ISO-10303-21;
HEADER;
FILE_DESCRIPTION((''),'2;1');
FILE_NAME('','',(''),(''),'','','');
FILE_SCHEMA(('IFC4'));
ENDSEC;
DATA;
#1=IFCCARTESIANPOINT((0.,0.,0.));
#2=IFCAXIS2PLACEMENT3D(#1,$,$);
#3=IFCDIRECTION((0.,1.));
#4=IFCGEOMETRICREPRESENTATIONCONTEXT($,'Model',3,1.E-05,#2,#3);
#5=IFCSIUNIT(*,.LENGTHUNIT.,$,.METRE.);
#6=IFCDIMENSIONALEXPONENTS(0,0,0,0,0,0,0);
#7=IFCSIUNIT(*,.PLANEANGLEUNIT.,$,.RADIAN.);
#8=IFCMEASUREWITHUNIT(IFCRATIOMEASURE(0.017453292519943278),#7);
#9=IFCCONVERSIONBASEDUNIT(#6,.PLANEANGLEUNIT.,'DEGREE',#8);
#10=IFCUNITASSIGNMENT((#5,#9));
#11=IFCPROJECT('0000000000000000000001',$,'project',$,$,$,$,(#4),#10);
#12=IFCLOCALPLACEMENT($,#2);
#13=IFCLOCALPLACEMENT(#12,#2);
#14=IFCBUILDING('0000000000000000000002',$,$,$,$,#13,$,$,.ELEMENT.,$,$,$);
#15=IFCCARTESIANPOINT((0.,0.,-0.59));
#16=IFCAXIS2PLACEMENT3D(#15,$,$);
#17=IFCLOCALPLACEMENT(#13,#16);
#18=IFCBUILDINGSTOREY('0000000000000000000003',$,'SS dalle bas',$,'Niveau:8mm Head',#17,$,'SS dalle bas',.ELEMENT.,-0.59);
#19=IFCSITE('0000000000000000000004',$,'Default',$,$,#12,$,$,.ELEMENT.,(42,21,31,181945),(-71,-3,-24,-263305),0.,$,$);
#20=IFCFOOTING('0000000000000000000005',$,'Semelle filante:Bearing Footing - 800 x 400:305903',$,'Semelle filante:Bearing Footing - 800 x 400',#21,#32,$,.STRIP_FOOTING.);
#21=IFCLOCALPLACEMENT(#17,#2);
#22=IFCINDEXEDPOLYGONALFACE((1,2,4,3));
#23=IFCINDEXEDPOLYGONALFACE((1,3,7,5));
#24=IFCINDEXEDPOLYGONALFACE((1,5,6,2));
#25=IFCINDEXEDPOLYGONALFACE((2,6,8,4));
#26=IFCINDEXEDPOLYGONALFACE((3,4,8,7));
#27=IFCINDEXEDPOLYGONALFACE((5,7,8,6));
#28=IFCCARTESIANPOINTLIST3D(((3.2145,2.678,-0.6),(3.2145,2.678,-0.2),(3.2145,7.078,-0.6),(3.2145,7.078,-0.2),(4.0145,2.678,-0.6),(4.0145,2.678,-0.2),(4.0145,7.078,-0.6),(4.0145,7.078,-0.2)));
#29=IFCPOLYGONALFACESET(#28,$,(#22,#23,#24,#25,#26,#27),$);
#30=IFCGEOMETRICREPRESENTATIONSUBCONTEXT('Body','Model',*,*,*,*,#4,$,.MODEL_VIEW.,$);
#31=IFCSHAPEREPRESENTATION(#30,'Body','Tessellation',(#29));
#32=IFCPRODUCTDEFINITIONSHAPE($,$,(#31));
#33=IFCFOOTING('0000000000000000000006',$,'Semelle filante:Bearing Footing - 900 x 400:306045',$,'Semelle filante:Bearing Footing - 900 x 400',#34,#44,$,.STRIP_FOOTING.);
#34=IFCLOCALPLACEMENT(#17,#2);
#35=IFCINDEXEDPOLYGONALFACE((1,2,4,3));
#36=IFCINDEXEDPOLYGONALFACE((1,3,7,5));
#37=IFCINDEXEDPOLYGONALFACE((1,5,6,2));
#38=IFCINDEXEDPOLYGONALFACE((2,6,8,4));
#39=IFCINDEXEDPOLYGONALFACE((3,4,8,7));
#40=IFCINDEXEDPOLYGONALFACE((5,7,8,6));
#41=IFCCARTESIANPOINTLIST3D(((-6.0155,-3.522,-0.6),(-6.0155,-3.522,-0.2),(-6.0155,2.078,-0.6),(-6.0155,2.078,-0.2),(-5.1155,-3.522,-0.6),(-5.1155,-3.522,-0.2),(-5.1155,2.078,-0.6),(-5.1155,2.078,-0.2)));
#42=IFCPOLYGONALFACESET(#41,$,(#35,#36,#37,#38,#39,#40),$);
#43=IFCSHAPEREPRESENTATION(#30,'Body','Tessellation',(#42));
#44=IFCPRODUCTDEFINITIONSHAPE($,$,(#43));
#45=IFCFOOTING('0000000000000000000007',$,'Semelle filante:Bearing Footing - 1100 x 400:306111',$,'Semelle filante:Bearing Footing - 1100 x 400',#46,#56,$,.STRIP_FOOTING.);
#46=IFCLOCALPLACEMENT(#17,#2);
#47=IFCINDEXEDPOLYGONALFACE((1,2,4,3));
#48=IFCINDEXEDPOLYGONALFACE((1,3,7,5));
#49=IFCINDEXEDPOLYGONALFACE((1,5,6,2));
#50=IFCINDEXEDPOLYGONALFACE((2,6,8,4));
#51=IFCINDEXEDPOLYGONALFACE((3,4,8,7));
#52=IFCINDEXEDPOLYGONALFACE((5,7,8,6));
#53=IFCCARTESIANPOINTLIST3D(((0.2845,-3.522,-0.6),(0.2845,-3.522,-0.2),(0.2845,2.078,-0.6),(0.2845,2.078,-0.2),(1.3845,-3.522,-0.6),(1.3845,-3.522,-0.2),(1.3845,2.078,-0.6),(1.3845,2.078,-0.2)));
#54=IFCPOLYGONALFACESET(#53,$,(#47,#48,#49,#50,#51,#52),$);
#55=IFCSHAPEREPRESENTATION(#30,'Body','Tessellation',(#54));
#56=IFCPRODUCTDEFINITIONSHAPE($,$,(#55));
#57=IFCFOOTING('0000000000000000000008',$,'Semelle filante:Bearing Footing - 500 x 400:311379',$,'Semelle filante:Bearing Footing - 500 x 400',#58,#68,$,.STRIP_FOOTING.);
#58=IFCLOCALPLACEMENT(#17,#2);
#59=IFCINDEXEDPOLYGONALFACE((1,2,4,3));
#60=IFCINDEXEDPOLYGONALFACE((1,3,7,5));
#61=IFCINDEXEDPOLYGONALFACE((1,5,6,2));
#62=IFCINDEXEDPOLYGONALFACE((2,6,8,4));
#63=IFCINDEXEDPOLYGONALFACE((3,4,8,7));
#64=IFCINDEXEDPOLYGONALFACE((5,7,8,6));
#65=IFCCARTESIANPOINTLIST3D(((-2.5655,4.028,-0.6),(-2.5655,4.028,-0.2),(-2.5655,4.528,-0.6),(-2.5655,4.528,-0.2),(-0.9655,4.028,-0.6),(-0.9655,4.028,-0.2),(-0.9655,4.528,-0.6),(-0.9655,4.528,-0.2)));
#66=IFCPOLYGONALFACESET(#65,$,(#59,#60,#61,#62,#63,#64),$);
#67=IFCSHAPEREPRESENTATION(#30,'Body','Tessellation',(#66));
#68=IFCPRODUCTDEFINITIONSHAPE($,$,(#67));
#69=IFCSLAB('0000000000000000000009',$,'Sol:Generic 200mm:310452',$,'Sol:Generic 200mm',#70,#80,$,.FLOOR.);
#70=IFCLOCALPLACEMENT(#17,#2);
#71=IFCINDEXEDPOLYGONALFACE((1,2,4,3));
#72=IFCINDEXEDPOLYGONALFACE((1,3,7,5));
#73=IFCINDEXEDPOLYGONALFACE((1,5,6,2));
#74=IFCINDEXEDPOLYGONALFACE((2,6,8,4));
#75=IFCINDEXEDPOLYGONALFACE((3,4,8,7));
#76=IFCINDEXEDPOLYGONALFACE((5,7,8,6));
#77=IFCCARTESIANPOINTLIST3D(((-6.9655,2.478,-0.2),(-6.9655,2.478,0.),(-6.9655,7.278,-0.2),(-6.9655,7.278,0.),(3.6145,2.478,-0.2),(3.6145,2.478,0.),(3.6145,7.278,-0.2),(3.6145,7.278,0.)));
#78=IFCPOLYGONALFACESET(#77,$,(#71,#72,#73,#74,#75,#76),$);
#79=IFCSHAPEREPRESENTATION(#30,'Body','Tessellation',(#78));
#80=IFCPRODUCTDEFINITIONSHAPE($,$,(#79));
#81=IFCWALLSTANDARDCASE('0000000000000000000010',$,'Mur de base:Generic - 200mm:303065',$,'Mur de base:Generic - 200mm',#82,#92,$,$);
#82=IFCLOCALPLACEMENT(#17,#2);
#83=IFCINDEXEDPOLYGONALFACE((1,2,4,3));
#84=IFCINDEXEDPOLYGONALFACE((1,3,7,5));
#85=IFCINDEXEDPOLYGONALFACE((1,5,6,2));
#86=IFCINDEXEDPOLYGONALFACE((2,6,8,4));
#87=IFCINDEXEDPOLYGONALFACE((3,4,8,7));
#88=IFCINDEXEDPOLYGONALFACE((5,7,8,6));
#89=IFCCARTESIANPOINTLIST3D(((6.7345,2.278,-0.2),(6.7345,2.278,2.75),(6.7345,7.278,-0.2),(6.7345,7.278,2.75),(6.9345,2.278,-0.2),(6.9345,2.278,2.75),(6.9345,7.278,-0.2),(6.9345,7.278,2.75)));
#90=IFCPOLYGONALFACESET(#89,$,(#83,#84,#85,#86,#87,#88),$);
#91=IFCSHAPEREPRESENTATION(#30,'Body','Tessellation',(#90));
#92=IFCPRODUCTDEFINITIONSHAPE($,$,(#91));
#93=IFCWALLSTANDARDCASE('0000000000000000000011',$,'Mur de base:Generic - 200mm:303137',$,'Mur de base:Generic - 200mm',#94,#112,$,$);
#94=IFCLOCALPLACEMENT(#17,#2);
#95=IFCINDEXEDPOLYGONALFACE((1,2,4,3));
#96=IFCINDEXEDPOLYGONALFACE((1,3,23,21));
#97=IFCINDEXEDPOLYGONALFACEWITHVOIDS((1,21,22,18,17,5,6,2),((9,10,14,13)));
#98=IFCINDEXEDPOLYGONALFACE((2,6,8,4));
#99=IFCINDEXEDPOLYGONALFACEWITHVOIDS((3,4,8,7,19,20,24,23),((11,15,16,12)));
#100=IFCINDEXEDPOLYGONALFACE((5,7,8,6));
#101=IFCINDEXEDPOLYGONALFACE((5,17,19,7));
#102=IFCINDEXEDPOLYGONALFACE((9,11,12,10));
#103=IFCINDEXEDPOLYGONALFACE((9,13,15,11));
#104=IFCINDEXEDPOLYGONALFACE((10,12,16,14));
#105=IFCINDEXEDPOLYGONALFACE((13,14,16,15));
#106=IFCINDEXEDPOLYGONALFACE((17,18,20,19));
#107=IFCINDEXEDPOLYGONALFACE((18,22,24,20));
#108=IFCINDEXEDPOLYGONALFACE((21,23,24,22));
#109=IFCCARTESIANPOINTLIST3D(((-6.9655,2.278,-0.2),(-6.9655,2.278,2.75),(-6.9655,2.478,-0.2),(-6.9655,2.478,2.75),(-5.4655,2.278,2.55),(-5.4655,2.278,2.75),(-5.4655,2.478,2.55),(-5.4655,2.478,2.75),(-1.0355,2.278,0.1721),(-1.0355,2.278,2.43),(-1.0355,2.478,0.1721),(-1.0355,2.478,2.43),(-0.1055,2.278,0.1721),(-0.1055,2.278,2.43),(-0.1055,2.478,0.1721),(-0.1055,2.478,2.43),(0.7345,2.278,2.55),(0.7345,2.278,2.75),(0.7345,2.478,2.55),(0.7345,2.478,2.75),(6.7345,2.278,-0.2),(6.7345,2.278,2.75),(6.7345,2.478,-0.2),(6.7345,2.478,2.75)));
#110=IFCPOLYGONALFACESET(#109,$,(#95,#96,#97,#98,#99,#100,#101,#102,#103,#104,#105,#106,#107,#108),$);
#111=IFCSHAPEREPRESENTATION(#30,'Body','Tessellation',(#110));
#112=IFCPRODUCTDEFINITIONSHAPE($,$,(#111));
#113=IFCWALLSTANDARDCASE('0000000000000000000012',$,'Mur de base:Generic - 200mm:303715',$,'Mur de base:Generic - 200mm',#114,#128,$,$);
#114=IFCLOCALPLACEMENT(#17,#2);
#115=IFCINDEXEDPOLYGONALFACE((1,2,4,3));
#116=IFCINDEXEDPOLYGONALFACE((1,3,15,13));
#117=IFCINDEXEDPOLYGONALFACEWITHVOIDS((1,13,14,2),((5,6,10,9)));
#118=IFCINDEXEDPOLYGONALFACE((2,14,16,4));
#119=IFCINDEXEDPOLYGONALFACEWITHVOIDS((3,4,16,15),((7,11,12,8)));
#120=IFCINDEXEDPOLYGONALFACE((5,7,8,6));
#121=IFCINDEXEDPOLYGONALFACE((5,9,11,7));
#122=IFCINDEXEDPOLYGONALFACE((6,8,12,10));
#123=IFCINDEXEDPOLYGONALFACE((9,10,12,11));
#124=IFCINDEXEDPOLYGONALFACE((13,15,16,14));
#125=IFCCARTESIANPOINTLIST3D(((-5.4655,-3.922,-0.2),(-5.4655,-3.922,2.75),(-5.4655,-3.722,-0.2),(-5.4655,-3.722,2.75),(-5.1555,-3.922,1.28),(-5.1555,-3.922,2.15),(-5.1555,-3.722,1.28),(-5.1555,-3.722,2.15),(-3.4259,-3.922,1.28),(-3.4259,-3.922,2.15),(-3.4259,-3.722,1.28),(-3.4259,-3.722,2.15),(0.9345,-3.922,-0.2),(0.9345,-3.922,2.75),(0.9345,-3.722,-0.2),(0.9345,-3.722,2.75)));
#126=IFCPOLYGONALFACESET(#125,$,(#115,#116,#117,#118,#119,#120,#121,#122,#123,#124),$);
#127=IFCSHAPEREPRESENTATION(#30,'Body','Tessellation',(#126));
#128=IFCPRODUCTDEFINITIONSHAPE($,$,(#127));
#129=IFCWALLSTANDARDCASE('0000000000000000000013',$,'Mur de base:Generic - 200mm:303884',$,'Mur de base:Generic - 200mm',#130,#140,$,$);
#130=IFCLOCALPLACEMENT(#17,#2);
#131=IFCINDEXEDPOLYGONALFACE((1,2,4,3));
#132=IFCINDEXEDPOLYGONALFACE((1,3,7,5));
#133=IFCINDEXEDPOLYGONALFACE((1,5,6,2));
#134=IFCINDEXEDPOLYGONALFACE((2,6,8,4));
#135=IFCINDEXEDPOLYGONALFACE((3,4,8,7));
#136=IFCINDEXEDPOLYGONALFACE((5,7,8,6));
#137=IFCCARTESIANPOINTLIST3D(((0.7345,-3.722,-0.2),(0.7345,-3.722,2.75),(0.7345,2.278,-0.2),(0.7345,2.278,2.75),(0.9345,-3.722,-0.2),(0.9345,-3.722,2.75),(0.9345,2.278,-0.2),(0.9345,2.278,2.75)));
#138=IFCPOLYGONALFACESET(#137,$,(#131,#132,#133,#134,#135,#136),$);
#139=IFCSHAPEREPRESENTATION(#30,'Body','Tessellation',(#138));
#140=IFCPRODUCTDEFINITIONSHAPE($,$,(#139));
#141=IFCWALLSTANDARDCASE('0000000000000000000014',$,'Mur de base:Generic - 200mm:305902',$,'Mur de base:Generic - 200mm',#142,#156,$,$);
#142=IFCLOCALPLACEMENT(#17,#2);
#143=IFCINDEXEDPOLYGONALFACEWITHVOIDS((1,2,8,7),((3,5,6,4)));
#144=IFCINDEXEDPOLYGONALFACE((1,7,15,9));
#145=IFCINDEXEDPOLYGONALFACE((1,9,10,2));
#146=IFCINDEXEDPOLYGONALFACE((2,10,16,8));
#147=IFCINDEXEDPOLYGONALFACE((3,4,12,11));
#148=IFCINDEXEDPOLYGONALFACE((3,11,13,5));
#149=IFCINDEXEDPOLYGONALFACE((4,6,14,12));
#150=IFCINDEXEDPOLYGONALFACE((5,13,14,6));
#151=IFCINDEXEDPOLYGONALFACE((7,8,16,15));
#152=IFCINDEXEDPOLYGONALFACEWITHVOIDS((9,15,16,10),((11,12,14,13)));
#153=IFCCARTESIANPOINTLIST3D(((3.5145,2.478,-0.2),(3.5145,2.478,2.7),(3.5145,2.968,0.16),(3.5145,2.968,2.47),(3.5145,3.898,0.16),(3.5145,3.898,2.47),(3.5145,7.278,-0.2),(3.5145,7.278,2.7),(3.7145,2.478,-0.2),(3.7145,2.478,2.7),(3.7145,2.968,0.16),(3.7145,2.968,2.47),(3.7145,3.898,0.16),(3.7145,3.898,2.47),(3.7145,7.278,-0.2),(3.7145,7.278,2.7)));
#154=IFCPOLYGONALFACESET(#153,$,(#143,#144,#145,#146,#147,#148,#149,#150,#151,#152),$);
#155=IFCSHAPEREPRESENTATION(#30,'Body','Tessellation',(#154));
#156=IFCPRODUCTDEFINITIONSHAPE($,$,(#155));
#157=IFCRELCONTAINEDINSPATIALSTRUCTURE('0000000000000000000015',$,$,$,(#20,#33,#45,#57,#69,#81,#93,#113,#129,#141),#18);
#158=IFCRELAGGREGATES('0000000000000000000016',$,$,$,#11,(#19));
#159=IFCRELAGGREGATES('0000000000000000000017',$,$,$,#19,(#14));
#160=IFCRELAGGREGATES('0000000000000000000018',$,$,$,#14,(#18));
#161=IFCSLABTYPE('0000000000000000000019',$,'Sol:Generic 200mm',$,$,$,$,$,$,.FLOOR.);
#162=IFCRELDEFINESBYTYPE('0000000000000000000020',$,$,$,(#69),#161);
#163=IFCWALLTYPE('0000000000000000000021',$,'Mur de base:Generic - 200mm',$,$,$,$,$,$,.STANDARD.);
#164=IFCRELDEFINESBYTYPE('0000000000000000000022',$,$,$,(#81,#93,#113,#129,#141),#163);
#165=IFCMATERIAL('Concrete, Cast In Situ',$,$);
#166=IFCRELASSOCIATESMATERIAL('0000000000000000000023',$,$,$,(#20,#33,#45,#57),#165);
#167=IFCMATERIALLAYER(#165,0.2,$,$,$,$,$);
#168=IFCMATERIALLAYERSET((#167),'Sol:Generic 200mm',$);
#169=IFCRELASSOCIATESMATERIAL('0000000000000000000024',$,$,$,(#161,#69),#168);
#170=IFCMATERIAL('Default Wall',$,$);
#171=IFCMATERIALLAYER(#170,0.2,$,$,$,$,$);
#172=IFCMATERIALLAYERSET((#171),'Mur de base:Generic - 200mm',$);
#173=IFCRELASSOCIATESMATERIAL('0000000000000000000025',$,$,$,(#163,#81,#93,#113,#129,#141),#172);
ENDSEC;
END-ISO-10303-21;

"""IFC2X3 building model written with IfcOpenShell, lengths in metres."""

from ifc_helpers import new_model, entity, si_unit, converted_unit, direction, frame, frame_2d, origin, origin_2d_with_axis, place, context, subcontext, project, spatial, polyline, rectangle, extrude, clip, bounded_halfspace, material, layer, layer_set, layer_usage, type_object, element, save


model = new_model("IFC2X3")

# Units and contexts
model_context = context("Model", 3, precision=1e-05, world=origin(), true_north=direction((0.0, 1.0)))
body_context = subcontext(model_context, "Body", "Model", "MODEL_VIEW")
ifc_project = project(units=[si_unit("LENGTHUNIT", "METRE"), converted_unit("PLANEANGLEUNIT", "DEGREE", entity("IfcRatioMeasure", 0.017453292519943278), si_unit("PLANEANGLEUNIT", "RADIAN"), dimensions=[0, 0, 0, 0, 0, 0, 0])], contexts=[model_context])

# Site, building, storey
site_placement = place(None, origin())
site = spatial("IfcSite", under=ifc_project, at=site_placement, Name="Default", CompositionType="ELEMENT", RefLatitude=(42, 21, 31, 181945), RefLongitude=(-71, -3, -24, -263305), RefElevation=0.0)
building_placement = place(site_placement, origin())
building = spatial("IfcBuilding", under=site, at=building_placement, CompositionType="ELEMENT")
storey_placement = place(building_placement, frame((0.0, 0.0, -0.59)))
storey = spatial("IfcBuildingStorey", under=building, at=storey_placement, Name="SS dalle bas", ObjectType="Niveau:8mm Head", LongName="SS dalle bas", CompositionType="ELEMENT", Elevation=-0.59)

# Footings
ifc_material_1 = material(Name="Concrete, Cast In Situ")
footing_1_placement = place(storey_placement, origin())
element("IfcFooting", 1, at=footing_1_placement, inside=storey, material=ifc_material_1, Name="Semelle filante:Bearing Footing - 800 x 400:305903", ObjectType="Semelle filante:Bearing Footing - 800 x 400", PredefinedType="STRIP_FOOTING", context=body_context, shape_type="SweptSolid", body=[
    extrude(rectangle(XDim=4.4, YDim=0.8, at=frame_2d((0.0, 0.0), x_axis=(1.0, 0.0))), frame((3.6145, 4.878, -0.6), z_axis=(0.0, 0.0, 1.0), x_axis=(0.0, -1.0, 0.0)), (0.0, 0.0, 1.0), 0.4),
])
footing_2_placement = place(storey_placement, origin())
element("IfcFooting", 2, at=footing_2_placement, inside=storey, material=ifc_material_1, Name="Semelle filante:Bearing Footing - 900 x 400:306045", ObjectType="Semelle filante:Bearing Footing - 900 x 400", PredefinedType="STRIP_FOOTING", context=body_context, shape_type="SweptSolid", body=[
    extrude(rectangle(XDim=5.6, YDim=0.9, at=frame_2d((0.0, 0.0), x_axis=(1.0, 0.0))), frame((-5.5655, -0.722, -0.6), z_axis=(0.0, 0.0, 1.0), x_axis=(0.0, -1.0, 0.0)), (0.0, 0.0, 1.0), 0.4),
])
footing_3_placement = place(storey_placement, origin())
element("IfcFooting", 3, at=footing_3_placement, inside=storey, material=ifc_material_1, Name="Semelle filante:Bearing Footing - 1100 x 400:306111", ObjectType="Semelle filante:Bearing Footing - 1100 x 400", PredefinedType="STRIP_FOOTING", context=body_context, shape_type="SweptSolid", body=[
    extrude(rectangle(XDim=5.6, YDim=1.1, at=frame_2d((0.0, 0.0), x_axis=(1.0, 0.0))), frame((0.8345, -0.722, -0.6), z_axis=(0.0, 0.0, 1.0), x_axis=(0.0, -1.0, 0.0)), (0.0, 0.0, 1.0), 0.4),
])
footing_4_placement = place(storey_placement, origin())
element("IfcFooting", 4, at=footing_4_placement, inside=storey, material=ifc_material_1, Name="Semelle filante:Bearing Footing - 500 x 400:311379", ObjectType="Semelle filante:Bearing Footing - 500 x 400", PredefinedType="STRIP_FOOTING", context=body_context, shape_type="SweptSolid", body=[
    extrude(rectangle(XDim=1.6, YDim=0.5, at=origin_2d_with_axis()), frame((-1.7655, 4.278, -0.6), z_axis=(0.0, 0.0, 1.0), x_axis=(-1.0, 0.0, 0.0)), (0.0, 0.0, 1.0), 0.4),
])

# Slab
ifc_layer_1 = layer(ifc_material_1, 0.2)
ifc_layer_set_1 = layer_set([ifc_layer_1], Name="Sol:Generic 200mm")
ifc_layer_usage_1 = layer_usage(ifc_layer_set_1, "AXIS3", "POSITIVE", 0.0)
slab_type = type_object("IfcSlabType", Name="Sol:Generic 200mm", PredefinedType="FLOOR", material=ifc_layer_set_1)
slab_placement = place(storey_placement, origin())
element("IfcSlab", 5, at=slab_placement, inside=storey, type_object=slab_type, material=ifc_layer_usage_1, Name="Sol:Generic 200mm:310452", ObjectType="Sol:Generic 200mm", PredefinedType="FLOOR", context=body_context, shape_type="SweptSolid", body=[
    extrude(rectangle(XDim=4.8, YDim=10.58, at=frame_2d((0.0, 0.0), x_axis=(1.0, 0.0))), frame((-1.6755, 4.878, 0.0), z_axis=(0.0, 0.0, -1.0), x_axis=(0.0, 1.0, 0.0)), (0.0, 0.0, 1.0), 0.2),
])

# Shared definitions
ifc_material_2 = material(Name="Default Wall")
ifc_layer_2 = layer(ifc_material_2, 0.2)
ifc_layer_set_2 = layer_set([ifc_layer_2], Name="Mur de base:Generic - 200mm")
ifc_layer_usage_2 = layer_usage(ifc_layer_set_2, "AXIS2", "NEGATIVE", 0.1)
wall_type = type_object("IfcWallType", Name="Mur de base:Generic - 200mm", PredefinedType="STANDARD", material=ifc_layer_set_2)

# Wall
wall_1_placement = place(storey_placement, frame((6.8345, 7.278, -0.2), z_axis=(0.0, 0.0, 1.0), x_axis=(0.0, -1.0, 0.0)))
element("IfcWallStandardCase", 6, at=wall_1_placement, inside=storey, type_object=wall_type, material=ifc_layer_usage_2, Name="Mur de base:Generic - 200mm:303065", ObjectType="Mur de base:Generic - 200mm", context=body_context, shape_type="SweptSolid", body=[
    extrude(rectangle(XDim=5.0, YDim=0.2, at=frame_2d((2.5, 0.0), x_axis=(-1.0, 0.0))), origin(), (0.0, 0.0, 1.0), 2.95),
])

# Walls, openings
wall_2_placement = place(storey_placement, frame((6.7345, 2.378, -0.2), z_axis=(0.0, 0.0, 1.0), x_axis=(-1.0, 0.0, 0.0)))
wall_2 = element("IfcWallStandardCase", 7, at=wall_2_placement, inside=storey, type_object=wall_type, material=ifc_layer_usage_2, Name="Mur de base:Generic - 200mm:303137", ObjectType="Mur de base:Generic - 200mm", context=body_context, shape_type="Clipping", body=[
    clip(extrude(rectangle(XDim=13.7, YDim=0.2, at=frame_2d((6.85, 0.0), x_axis=(-1.0, 0.0))), origin(), (0.0, 0.0, 1.0), 2.95), bounded_halfspace(frame((12.2, -0.1, 2.75), z_axis=(0.0, 0.0, -1.0), x_axis=(0.0, 1.0, 0.0)), True, frame((12.2, -0.1, 2.75), z_axis=(0.0, 0.0, -1.0), x_axis=(0.0, 1.0, 0.0)), polyline([(0.0, 0.0), (0.0, -2.5), (0.0, -2.7), (0.0, -6.2), (0.2, -6.2), (0.2, 0.0), (0.0, 0.0)]))),
])
opening_1_placement = place(wall_2_placement, origin())
element("IfcOpeningElement", 8, at=opening_1_placement, cuts=wall_2, ObjectType="Opening", context=body_context, shape_type="SweptSolid", body=[
    extrude(rectangle(XDim=2.2579, YDim=0.93, at=origin_2d_with_axis()), frame((7.305, -0.1, 1.5011), z_axis=(0.0, 1.0, 0.0), x_axis=(0.0, 0.0, -1.0)), (0.0, 0.0, 1.0), 0.2),
])
wall_3_placement = place(storey_placement, frame((-5.4655, -3.822, -0.2)))
wall_3 = element("IfcWallStandardCase", 9, at=wall_3_placement, inside=storey, type_object=wall_type, material=ifc_layer_usage_2, Name="Mur de base:Generic - 200mm:303715", ObjectType="Mur de base:Generic - 200mm", context=body_context, shape_type="SweptSolid", body=[
    extrude(rectangle(XDim=6.4, YDim=0.2, at=frame_2d((3.2, 0.0), x_axis=(-1.0, 0.0))), origin(), (0.0, 0.0, 1.0), 2.95),
])
opening_2_placement = place(wall_3_placement, origin())
element("IfcOpeningElement", 10, at=opening_2_placement, cuts=wall_3, ObjectType="Opening", context=body_context, shape_type="SweptSolid", body=[
    extrude(rectangle(XDim=0.87, YDim=1.7296, at=origin_2d_with_axis()), frame((1.1748, -0.1, 1.915), z_axis=(0.0, 1.0, 0.0), x_axis=(0.0, 0.0, -1.0)), (0.0, 0.0, 1.0), 0.2),
])

# Wall
wall_4_placement = place(storey_placement, frame((0.8345, -3.722, -0.2), z_axis=(0.0, 0.0, 1.0), x_axis=(0.0, 1.0, 0.0)))
element("IfcWallStandardCase", 11, at=wall_4_placement, inside=storey, type_object=wall_type, material=ifc_layer_usage_2, Name="Mur de base:Generic - 200mm:303884", ObjectType="Mur de base:Generic - 200mm", context=body_context, shape_type="SweptSolid", body=[
    extrude(rectangle(XDim=6.0, YDim=0.2, at=frame_2d((3.0, 0.0), x_axis=(-1.0, 0.0))), origin(), (0.0, 0.0, 1.0), 2.95),
])

# Wall, opening
wall_5_placement = place(storey_placement, frame((3.6145, 7.278, -0.2), z_axis=(0.0, 0.0, 1.0), x_axis=(0.0, -1.0, 0.0)))
wall_5 = element("IfcWallStandardCase", 12, at=wall_5_placement, inside=storey, type_object=wall_type, material=ifc_layer_usage_2, Name="Mur de base:Generic - 200mm:305902", ObjectType="Mur de base:Generic - 200mm", context=body_context, shape_type="SweptSolid", body=[
    extrude(rectangle(XDim=4.8, YDim=0.2, at=frame_2d((2.4, 0.0), x_axis=(-1.0, 0.0))), origin(), (0.0, 0.0, 1.0), 2.9),
])
opening_3_placement = place(wall_5_placement, origin())
element("IfcOpeningElement", 13, at=opening_3_placement, cuts=wall_5, ObjectType="Opening", context=body_context, shape_type="SweptSolid", body=[
    extrude(rectangle(XDim=2.31, YDim=0.93, at=frame_2d((0.0, 0.0), x_axis=(0.0, 1.0))), frame((3.845, 0.1, 1.515), z_axis=(0.0, -1.0, 0.0), x_axis=(-1.0, 0.0, 0.0)), (0.0, 0.0, 1.0), 0.2),
])

save(model, "model.ifc")
